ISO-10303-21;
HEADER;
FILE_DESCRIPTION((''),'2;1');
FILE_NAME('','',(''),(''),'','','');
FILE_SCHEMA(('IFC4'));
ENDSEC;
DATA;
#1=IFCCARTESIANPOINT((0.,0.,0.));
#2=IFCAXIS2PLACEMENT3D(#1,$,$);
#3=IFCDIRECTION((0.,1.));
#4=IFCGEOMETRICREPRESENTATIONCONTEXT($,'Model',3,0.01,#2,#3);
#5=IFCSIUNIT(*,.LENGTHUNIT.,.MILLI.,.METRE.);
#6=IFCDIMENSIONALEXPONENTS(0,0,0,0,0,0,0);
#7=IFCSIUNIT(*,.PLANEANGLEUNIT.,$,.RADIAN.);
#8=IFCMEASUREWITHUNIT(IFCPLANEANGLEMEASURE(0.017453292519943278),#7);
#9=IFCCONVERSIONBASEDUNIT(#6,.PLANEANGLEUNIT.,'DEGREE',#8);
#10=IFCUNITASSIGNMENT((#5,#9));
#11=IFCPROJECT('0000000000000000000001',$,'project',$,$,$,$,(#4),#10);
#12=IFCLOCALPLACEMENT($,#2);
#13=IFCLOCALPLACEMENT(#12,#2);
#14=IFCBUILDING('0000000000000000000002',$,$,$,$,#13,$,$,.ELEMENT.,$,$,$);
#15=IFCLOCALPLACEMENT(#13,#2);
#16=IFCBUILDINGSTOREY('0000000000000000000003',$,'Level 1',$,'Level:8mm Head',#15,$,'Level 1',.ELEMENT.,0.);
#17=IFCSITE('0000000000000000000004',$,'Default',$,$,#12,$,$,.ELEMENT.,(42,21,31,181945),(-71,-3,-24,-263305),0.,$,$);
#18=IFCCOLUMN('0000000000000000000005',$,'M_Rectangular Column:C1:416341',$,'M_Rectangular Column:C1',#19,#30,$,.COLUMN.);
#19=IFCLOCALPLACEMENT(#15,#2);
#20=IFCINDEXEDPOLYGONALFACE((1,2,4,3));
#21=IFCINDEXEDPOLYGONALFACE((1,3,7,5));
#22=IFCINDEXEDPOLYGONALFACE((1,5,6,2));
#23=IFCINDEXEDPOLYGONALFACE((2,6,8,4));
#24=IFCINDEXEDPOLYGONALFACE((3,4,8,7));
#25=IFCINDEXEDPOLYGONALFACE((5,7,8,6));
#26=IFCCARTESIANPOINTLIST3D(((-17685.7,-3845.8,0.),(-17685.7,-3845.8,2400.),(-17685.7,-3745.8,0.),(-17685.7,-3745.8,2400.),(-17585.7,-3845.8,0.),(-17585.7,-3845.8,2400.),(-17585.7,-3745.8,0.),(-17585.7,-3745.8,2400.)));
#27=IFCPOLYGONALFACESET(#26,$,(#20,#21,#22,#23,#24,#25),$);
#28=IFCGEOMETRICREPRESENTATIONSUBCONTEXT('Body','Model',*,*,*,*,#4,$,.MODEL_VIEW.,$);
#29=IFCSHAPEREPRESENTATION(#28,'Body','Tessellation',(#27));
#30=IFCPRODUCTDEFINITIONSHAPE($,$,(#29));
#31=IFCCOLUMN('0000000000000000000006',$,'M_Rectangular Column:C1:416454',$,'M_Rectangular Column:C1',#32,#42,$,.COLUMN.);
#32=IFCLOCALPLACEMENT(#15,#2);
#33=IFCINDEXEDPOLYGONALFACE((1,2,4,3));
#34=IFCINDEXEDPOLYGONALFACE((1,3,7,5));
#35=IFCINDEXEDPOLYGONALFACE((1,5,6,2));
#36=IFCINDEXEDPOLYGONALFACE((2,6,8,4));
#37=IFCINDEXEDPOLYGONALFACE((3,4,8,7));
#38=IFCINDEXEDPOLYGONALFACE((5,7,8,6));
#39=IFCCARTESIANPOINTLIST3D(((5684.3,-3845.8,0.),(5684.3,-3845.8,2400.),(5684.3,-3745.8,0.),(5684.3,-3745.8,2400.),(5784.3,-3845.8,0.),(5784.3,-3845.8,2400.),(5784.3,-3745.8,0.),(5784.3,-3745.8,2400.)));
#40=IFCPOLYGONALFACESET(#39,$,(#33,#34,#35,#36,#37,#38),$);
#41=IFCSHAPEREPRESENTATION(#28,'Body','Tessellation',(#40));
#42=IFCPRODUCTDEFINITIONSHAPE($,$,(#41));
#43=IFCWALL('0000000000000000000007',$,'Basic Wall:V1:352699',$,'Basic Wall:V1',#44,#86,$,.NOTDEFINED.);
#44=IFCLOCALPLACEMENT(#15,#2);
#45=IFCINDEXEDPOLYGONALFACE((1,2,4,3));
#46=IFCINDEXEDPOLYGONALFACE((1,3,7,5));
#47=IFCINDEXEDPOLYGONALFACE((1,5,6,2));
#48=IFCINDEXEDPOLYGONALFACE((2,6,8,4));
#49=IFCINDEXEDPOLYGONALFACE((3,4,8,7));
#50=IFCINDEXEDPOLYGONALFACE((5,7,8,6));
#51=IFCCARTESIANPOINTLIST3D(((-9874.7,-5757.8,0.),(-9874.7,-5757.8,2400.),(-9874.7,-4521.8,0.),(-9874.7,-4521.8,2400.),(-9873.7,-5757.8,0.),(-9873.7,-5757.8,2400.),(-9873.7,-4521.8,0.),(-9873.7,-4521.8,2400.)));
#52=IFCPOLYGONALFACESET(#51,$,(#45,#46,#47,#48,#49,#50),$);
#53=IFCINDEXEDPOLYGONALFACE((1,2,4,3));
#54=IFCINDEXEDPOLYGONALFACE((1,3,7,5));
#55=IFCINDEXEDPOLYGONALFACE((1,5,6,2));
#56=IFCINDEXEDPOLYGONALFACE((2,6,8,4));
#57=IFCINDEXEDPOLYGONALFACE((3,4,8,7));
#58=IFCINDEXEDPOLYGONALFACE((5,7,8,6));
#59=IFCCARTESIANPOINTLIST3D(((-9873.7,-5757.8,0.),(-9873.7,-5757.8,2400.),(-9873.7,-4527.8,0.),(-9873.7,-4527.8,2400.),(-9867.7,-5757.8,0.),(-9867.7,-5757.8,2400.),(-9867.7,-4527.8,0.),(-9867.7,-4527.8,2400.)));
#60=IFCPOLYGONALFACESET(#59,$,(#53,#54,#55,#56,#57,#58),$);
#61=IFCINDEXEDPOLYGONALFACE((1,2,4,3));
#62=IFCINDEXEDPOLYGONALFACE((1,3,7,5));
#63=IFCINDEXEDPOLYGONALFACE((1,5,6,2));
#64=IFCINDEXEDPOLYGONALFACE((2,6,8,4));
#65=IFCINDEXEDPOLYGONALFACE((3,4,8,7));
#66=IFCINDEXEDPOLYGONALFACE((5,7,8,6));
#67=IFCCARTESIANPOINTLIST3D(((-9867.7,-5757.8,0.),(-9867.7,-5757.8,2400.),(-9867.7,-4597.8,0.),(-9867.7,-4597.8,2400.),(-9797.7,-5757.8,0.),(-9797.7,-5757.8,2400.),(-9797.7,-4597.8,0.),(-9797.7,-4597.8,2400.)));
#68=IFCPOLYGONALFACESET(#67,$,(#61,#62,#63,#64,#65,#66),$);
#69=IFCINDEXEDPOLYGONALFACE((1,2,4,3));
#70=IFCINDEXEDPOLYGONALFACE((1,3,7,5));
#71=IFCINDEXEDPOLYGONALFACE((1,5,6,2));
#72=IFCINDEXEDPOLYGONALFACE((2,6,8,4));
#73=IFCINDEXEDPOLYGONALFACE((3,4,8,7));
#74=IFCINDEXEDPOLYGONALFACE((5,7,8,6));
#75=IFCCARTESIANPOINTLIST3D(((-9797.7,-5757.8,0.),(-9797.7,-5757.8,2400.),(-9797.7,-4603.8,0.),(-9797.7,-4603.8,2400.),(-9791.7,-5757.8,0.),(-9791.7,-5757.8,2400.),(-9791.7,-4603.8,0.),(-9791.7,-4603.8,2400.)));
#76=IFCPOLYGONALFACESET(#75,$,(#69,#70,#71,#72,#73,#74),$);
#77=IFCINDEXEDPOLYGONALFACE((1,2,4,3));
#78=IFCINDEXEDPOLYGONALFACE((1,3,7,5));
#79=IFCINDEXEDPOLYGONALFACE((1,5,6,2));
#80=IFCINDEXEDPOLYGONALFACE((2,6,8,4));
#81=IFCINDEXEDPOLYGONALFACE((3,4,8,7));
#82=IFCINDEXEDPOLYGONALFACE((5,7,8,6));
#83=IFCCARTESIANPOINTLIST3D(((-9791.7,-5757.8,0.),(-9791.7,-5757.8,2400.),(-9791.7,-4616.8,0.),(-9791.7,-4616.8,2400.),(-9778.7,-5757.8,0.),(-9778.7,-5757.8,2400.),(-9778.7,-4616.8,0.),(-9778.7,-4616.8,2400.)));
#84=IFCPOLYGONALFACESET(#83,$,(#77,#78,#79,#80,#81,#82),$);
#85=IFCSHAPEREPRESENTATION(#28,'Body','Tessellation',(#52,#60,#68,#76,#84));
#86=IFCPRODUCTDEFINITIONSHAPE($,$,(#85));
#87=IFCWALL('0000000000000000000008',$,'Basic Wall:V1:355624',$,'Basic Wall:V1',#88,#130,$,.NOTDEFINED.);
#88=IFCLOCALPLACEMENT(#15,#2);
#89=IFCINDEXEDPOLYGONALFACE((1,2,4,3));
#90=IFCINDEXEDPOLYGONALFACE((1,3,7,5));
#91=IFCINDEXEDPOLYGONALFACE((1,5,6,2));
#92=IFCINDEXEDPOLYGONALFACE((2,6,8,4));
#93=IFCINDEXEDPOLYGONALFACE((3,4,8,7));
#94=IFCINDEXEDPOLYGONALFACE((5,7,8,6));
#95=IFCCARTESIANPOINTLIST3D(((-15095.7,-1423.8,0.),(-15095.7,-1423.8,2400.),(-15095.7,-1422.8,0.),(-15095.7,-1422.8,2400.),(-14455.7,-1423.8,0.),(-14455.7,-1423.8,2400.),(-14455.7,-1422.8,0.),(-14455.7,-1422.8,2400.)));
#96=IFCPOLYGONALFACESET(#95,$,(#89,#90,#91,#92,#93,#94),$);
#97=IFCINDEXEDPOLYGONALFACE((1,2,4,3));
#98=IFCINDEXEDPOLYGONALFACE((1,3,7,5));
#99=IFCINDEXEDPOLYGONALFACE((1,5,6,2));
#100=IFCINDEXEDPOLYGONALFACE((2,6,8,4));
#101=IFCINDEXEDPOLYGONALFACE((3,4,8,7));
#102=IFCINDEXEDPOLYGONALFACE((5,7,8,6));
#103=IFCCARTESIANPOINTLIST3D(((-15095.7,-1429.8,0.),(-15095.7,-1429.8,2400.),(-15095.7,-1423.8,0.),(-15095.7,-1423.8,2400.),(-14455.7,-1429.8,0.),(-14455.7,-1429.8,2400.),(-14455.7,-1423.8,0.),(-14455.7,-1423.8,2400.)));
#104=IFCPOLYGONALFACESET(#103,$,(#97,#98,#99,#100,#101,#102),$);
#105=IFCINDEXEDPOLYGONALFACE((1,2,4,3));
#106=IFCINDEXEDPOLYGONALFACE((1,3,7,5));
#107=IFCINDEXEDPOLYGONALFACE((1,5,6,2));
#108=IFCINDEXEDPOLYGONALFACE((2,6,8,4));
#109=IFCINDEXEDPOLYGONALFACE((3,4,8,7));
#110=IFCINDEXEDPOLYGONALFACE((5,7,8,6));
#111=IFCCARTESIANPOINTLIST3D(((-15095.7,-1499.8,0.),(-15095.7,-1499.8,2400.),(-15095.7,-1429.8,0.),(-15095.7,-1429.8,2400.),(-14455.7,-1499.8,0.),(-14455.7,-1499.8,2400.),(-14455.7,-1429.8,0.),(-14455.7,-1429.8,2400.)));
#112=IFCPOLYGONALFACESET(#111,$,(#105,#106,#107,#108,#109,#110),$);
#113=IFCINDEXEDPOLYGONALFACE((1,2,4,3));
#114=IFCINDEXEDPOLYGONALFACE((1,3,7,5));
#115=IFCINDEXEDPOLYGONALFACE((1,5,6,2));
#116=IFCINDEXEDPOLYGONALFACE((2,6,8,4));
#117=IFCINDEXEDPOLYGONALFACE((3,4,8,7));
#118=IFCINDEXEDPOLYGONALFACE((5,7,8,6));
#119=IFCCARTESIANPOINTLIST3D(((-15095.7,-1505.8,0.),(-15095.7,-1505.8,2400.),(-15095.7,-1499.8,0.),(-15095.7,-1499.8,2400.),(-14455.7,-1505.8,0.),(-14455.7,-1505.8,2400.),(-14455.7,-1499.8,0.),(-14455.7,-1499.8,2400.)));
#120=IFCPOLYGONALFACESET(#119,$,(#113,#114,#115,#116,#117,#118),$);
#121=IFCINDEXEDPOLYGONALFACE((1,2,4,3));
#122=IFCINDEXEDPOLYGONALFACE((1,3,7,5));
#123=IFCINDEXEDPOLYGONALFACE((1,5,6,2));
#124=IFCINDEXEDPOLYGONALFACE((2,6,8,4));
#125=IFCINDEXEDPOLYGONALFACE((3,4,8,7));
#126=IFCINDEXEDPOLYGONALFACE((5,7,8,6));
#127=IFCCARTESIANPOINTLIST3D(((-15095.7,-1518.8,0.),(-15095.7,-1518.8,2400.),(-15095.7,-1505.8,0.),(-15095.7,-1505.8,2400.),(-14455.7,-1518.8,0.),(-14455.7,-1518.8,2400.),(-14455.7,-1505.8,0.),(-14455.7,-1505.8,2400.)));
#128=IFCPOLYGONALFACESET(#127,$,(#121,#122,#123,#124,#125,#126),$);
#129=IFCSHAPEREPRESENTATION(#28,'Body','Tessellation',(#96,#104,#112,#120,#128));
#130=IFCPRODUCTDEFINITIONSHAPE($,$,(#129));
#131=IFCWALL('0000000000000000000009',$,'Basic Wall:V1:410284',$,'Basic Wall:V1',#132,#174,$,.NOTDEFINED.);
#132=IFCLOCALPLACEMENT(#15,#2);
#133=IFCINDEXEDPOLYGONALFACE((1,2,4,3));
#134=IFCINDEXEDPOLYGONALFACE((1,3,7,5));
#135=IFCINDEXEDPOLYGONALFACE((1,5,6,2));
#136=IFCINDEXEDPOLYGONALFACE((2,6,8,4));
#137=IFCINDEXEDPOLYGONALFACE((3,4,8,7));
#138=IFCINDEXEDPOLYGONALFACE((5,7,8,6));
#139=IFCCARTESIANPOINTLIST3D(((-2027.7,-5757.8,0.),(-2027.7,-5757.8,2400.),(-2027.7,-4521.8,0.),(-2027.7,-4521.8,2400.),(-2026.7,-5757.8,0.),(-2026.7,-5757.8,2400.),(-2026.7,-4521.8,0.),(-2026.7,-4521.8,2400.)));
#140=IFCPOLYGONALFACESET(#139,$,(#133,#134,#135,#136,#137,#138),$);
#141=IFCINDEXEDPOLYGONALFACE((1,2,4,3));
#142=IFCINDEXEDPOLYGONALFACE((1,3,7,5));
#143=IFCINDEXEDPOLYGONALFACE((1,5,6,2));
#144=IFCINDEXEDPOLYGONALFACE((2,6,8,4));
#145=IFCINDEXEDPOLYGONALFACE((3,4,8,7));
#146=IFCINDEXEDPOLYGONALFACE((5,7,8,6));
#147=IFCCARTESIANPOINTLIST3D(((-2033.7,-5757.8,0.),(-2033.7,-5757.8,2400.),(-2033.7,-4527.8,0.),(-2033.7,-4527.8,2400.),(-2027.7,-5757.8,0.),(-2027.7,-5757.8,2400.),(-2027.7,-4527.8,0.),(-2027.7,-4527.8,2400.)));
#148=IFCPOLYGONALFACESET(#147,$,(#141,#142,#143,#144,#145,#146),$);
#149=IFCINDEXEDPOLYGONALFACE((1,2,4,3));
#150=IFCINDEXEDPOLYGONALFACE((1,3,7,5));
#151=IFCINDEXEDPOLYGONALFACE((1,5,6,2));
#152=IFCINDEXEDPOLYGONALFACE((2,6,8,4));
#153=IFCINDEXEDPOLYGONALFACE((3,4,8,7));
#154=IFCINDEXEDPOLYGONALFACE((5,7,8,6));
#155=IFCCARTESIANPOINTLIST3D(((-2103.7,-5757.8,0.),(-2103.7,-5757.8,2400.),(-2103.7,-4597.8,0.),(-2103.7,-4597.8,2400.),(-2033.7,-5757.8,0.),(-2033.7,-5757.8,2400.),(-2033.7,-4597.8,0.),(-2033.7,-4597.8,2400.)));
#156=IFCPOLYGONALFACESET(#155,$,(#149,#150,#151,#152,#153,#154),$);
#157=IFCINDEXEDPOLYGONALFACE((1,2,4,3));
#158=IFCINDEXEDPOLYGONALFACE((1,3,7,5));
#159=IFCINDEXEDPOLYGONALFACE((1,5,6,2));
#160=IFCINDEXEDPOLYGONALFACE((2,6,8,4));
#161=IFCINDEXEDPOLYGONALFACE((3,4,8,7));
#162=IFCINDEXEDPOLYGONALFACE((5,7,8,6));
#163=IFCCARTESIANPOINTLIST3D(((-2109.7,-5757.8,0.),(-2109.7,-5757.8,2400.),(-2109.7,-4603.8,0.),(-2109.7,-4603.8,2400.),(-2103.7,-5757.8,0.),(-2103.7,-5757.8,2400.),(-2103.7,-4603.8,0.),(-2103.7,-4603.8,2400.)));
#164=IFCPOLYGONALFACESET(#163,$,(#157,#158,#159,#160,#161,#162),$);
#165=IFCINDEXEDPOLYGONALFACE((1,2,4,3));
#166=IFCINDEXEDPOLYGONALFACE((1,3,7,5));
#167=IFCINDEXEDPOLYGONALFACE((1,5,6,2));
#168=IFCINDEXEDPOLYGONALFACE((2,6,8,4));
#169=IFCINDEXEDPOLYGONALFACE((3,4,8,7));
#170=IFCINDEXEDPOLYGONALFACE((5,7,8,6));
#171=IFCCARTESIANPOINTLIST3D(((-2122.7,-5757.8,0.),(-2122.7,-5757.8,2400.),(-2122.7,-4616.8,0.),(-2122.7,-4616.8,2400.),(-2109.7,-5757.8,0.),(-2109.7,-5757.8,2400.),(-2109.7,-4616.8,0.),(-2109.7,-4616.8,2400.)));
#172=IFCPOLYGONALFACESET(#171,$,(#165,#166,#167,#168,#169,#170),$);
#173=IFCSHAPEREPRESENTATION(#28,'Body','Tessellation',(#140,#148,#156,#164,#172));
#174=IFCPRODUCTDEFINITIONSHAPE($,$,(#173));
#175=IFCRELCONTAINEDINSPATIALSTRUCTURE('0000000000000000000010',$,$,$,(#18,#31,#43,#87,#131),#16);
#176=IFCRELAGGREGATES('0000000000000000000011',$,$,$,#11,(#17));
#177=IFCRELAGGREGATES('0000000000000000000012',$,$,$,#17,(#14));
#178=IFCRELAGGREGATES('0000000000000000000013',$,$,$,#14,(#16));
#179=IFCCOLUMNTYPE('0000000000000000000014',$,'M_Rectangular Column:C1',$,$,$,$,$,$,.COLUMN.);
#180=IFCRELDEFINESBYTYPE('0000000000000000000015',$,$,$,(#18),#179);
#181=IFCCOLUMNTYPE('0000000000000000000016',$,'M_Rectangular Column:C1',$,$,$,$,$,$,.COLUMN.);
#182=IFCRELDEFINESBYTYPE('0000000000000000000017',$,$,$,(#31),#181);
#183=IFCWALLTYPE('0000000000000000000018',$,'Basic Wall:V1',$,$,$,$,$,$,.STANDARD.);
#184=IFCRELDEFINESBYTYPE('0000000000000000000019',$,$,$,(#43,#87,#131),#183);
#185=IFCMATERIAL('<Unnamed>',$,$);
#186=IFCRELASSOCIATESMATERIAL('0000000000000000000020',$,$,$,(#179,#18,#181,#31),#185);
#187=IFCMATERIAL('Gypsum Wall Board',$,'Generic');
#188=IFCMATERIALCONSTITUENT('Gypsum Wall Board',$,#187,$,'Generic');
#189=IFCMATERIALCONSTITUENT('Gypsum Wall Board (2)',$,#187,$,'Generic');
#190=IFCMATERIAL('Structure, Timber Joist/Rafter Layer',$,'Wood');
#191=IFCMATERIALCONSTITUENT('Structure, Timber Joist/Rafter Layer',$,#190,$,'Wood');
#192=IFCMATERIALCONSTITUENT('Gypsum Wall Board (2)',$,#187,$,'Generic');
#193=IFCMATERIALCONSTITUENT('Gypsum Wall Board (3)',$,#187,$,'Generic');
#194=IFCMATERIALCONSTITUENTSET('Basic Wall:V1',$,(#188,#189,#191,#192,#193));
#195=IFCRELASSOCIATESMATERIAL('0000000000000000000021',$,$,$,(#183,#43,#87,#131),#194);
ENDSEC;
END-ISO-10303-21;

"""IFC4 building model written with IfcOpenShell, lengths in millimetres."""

from ifc_helpers import new_model, entity, si_unit, converted_unit, direction, frame, origin, place, context, subcontext, project, spatial, indexed_curve, outline, extrude, source, transform, mapped, material, constituent, constituent_set, type_object, type_shapes, element, save


model = new_model("IFC4")

# Units and contexts
model_context = context("Model", 3, precision=0.01, world=origin(), true_north=direction((0.0, 1.0)))
body_context = subcontext(model_context, "Body", "Model", "MODEL_VIEW")
ifc_project = project(units=[si_unit("LENGTHUNIT", "METRE", prefix="MILLI"), converted_unit("PLANEANGLEUNIT", "DEGREE", entity("IfcPlaneAngleMeasure", 0.017453292519943278), si_unit("PLANEANGLEUNIT", "RADIAN"), dimensions=[0, 0, 0, 0, 0, 0, 0])], contexts=[model_context])

# Site, building, storey
site_placement = place(None, origin())
site = spatial("IfcSite", under=ifc_project, at=site_placement, Name="Default", CompositionType="ELEMENT", RefLatitude=(42, 21, 31, 181945), RefLongitude=(-71, -3, -24, -263305), RefElevation=0.0)
building_placement = place(site_placement, origin())
building = spatial("IfcBuilding", under=site, at=building_placement, CompositionType="ELEMENT")
storey_placement = place(building_placement, origin())
storey = spatial("IfcBuildingStorey", under=building, at=storey_placement, Name="Level 1", ObjectType="Level:8mm Head", LongName="Level 1", CompositionType="ELEMENT", Elevation=0.0)

# Columns
ifc_material_1 = material(Name="<Unnamed>")
column_type_1 = type_object("IfcColumnType", Name="M_Rectangular Column:C1", PredefinedType="COLUMN", material=ifc_material_1)
shared_shape_1 = source(origin(), body_context, "Body", "SweptSolid", [
    extrude(outline(indexed_curve([(-50.0, -50.0), (50.0, -50.0), (50.0, 50.0), (-50.0, 50.0), (-50.0, -50.0)], self_intersect=False)), frame((-17635.7, -3795.8, 0.0), z_axis=(0.0, 0.0, 1.0), x_axis=(-1.0, 0.0, 0.0)), (0.0, 0.0, 1.0), 2400.0),
])
type_shapes(column_type_1, [shared_shape_1])
column_1_placement = place(storey_placement, origin())
element("IfcColumn", 1, at=column_1_placement, inside=storey, type_object=column_type_1, material=ifc_material_1, Name="M_Rectangular Column:C1:416341", ObjectType="M_Rectangular Column:C1", PredefinedType="COLUMN", context=body_context, shape_type="MappedRepresentation", body=[
    mapped(shared_shape_1, transform((0.0, 0.0, 0.0), scale=1.0)),
])
column_type_2 = type_object("IfcColumnType", Name="M_Rectangular Column:C1", PredefinedType="COLUMN", material=ifc_material_1)
shared_shape_2 = source(origin(), body_context, "Body", "SweptSolid", [
    extrude(outline(indexed_curve([(-50.0, -50.0), (50.0, -50.0), (50.0, 50.0), (-50.0, 50.0), (-50.0, -50.0)], self_intersect=False)), frame((5734.3, -3795.8, 0.0), z_axis=(0.0, 0.0, 1.0), x_axis=(0.0, -1.0, 0.0)), (0.0, 0.0, 1.0), 2400.0),
])
type_shapes(column_type_2, [shared_shape_2])
column_2_placement = place(storey_placement, origin())
element("IfcColumn", 2, at=column_2_placement, inside=storey, type_object=column_type_2, material=ifc_material_1, Name="M_Rectangular Column:C1:416454", ObjectType="M_Rectangular Column:C1", PredefinedType="COLUMN", context=body_context, shape_type="MappedRepresentation", body=[
    mapped(shared_shape_2, transform((0.0, 0.0, 0.0), scale=1.0)),
])

# Walls
ifc_material_2 = material(Name="Gypsum Wall Board", Category="Generic")
ifc_constituent_1 = constituent(ifc_material_2, Name="Gypsum Wall Board", Category="Generic")
ifc_constituent_2 = constituent(ifc_material_2, Name="Gypsum Wall Board (2)", Category="Generic")
ifc_material_3 = material(Name="Structure, Timber Joist/Rafter Layer", Category="Wood")
ifc_constituent_3 = constituent(ifc_material_3, Name="Structure, Timber Joist/Rafter Layer", Category="Wood")
ifc_constituent_4 = constituent(ifc_material_2, Name="Gypsum Wall Board (2)", Category="Generic")
ifc_constituent_5 = constituent(ifc_material_2, Name="Gypsum Wall Board (3)", Category="Generic")
ifc_constituent_set_1 = constituent_set(constituents=[ifc_constituent_1, ifc_constituent_2, ifc_constituent_3, ifc_constituent_4, ifc_constituent_5], Name="Basic Wall:V1")
wall_type_1 = type_object("IfcWallType", Name="Basic Wall:V1", PredefinedType="STANDARD", material=ifc_constituent_set_1)
wall_1_placement = place(storey_placement, frame((-9826.7, -4616.8, 0.0), z_axis=(0.0, 0.0, 1.0), x_axis=(0.0, -1.0, 0.0)))
element("IfcWall", 3, at=wall_1_placement, inside=storey, type_object=wall_type_1, material=ifc_constituent_set_1, Name="Basic Wall:V1:352699", ObjectType="Basic Wall:V1", PredefinedType="NOTDEFINED", context=body_context, shape_type="SweptSolid", body=[
    extrude(outline(indexed_curve([(-1200.0, -618.0), (1200.0, -618.0), (1200.0, 618.0), (-1200.0, 618.0), (-1200.0, -618.0)], self_intersect=False)), frame((523.0, -48.0, 1200.0), z_axis=(0.0, 1.0, 0.0), x_axis=(0.0, 0.0, 1.0)), (0.0, 0.0, 1.0), 1.0),
    extrude(outline(indexed_curve([(-1200.0, -615.0), (1200.0, -615.0), (1200.0, 615.0), (-1200.0, 615.0), (-1200.0, -615.0)], self_intersect=False)), frame((526.0, -47.0, 1200.0), z_axis=(0.0, 1.0, 0.0), x_axis=(0.0, 0.0, 1.0)), (0.0, 0.0, 1.0), 6.0),
    extrude(outline(indexed_curve([(-1200.0, -580.0), (1200.0, -580.0), (1200.0, 580.0), (-1200.0, 580.0), (-1200.0, -580.0)], self_intersect=False)), frame((561.0, -41.0, 1200.0), z_axis=(0.0, 1.0, 0.0), x_axis=(0.0, 0.0, 1.0)), (0.0, 0.0, 1.0), 70.0),
    extrude(outline(indexed_curve([(-1200.0, -577.0), (1200.0, -577.0), (1200.0, 577.0), (-1200.0, 577.0), (-1200.0, -577.0)], self_intersect=False)), frame((564.0, 29.0, 1200.0), z_axis=(0.0, 1.0, 0.0), x_axis=(0.0, 0.0, 1.0)), (0.0, 0.0, 1.0), 6.0),
    extrude(outline(indexed_curve([(-1200.0, -570.5), (1200.0, -570.5), (1200.0, 570.5), (-1200.0, 570.5), (-1200.0, -570.5)], self_intersect=False)), frame((570.5, 35.0, 1200.0), z_axis=(0.0, 1.0, 0.0), x_axis=(0.0, 0.0, 1.0)), (0.0, 0.0, 1.0), 13.0),
])
wall_2_placement = place(storey_placement, frame((-14455.7, -1470.8, 0.0), z_axis=(0.0, 0.0, 1.0), x_axis=(-1.0, 0.0, 0.0)))
element("IfcWall", 4, at=wall_2_placement, inside=storey, type_object=wall_type_1, material=ifc_constituent_set_1, Name="Basic Wall:V1:355624", ObjectType="Basic Wall:V1", PredefinedType="NOTDEFINED", context=body_context, shape_type="SweptSolid", body=[
    extrude(outline(indexed_curve([(-0.5, -320.0), (0.5, -320.0), (0.5, 320.0), (-0.5, 320.0), (-0.5, -320.0)], self_intersect=False)), frame((320.0, -47.5, 0.0), z_axis=(0.0, 0.0, 1.0), x_axis=(0.0, 1.0, 0.0)), (0.0, 0.0, 1.0), 2400.0),
    extrude(outline(indexed_curve([(-320.0, -3.0), (320.0, -3.0), (320.0, 3.0), (-320.0, 3.0), (-320.0, -3.0)], self_intersect=False)), frame((320.0, -44.0, 0.0)), (0.0, 0.0, 1.0), 2400.0),
    extrude(outline(indexed_curve([(-320.0, -35.0), (320.0, -35.0), (320.0, 35.0), (-320.0, 35.0), (-320.0, -35.0)], self_intersect=False)), frame((320.0, -6.0, 0.0)), (0.0, 0.0, 1.0), 2400.0),
    extrude(outline(indexed_curve([(-320.0, -3.0), (320.0, -3.0), (320.0, 3.0), (-320.0, 3.0), (-320.0, -3.0)], self_intersect=False)), frame((320.0, 32.0, 0.0)), (0.0, 0.0, 1.0), 2400.0),
    extrude(outline(indexed_curve([(-6.5, -320.0), (6.5, -320.0), (6.5, 320.0), (-6.5, 320.0), (-6.5, -320.0)], self_intersect=False)), frame((320.0, 41.5, 0.0), z_axis=(0.0, 0.0, 1.0), x_axis=(0.0, -1.0, 0.0)), (0.0, 0.0, 1.0), 2400.0),
])
wall_3_placement = place(storey_placement, frame((-2074.7, -4616.8, 0.0), z_axis=(0.0, 0.0, 1.0), x_axis=(0.0, -1.0, 0.0)))
element("IfcWall", 5, at=wall_3_placement, inside=storey, type_object=wall_type_1, material=ifc_constituent_set_1, Name="Basic Wall:V1:410284", ObjectType="Basic Wall:V1", PredefinedType="NOTDEFINED", context=body_context, shape_type="SweptSolid", body=[
    extrude(outline(indexed_curve([(-1200.0, -618.0), (1200.0, -618.0), (1200.0, 618.0), (-1200.0, 618.0), (-1200.0, -618.0)], self_intersect=False)), frame((523.0, 47.0, 1200.0), z_axis=(0.0, 1.0, 0.0), x_axis=(0.0, 0.0, 1.0)), (0.0, 0.0, 1.0), 1.0),
    extrude(outline(indexed_curve([(-1200.0, -615.0), (1200.0, -615.0), (1200.0, 615.0), (-1200.0, 615.0), (-1200.0, -615.0)], self_intersect=False)), frame((526.0, 41.0, 1200.0), z_axis=(0.0, 1.0, 0.0), x_axis=(0.0, 0.0, 1.0)), (0.0, 0.0, 1.0), 6.0),
    extrude(outline(indexed_curve([(-1200.0, -580.0), (1200.0, -580.0), (1200.0, 580.0), (-1200.0, 580.0), (-1200.0, -580.0)], self_intersect=False)), frame((561.0, -29.0, 1200.0), z_axis=(0.0, 1.0, 0.0), x_axis=(0.0, 0.0, 1.0)), (0.0, 0.0, 1.0), 70.0),
    extrude(outline(indexed_curve([(-1200.0, -577.0), (1200.0, -577.0), (1200.0, 577.0), (-1200.0, 577.0), (-1200.0, -577.0)], self_intersect=False)), frame((564.0, -35.0, 1200.0), z_axis=(0.0, 1.0, 0.0), x_axis=(0.0, 0.0, 1.0)), (0.0, 0.0, 1.0), 6.0),
    extrude(outline(indexed_curve([(-1200.0, -570.5), (1200.0, -570.5), (1200.0, 570.5), (-1200.0, 570.5), (-1200.0, -570.5)], self_intersect=False)), frame((570.5, -48.0, 1200.0), z_axis=(0.0, 1.0, 0.0), x_axis=(0.0, 0.0, 1.0)), (0.0, 0.0, 1.0), 13.0),
])

save(model, "model.ifc")
